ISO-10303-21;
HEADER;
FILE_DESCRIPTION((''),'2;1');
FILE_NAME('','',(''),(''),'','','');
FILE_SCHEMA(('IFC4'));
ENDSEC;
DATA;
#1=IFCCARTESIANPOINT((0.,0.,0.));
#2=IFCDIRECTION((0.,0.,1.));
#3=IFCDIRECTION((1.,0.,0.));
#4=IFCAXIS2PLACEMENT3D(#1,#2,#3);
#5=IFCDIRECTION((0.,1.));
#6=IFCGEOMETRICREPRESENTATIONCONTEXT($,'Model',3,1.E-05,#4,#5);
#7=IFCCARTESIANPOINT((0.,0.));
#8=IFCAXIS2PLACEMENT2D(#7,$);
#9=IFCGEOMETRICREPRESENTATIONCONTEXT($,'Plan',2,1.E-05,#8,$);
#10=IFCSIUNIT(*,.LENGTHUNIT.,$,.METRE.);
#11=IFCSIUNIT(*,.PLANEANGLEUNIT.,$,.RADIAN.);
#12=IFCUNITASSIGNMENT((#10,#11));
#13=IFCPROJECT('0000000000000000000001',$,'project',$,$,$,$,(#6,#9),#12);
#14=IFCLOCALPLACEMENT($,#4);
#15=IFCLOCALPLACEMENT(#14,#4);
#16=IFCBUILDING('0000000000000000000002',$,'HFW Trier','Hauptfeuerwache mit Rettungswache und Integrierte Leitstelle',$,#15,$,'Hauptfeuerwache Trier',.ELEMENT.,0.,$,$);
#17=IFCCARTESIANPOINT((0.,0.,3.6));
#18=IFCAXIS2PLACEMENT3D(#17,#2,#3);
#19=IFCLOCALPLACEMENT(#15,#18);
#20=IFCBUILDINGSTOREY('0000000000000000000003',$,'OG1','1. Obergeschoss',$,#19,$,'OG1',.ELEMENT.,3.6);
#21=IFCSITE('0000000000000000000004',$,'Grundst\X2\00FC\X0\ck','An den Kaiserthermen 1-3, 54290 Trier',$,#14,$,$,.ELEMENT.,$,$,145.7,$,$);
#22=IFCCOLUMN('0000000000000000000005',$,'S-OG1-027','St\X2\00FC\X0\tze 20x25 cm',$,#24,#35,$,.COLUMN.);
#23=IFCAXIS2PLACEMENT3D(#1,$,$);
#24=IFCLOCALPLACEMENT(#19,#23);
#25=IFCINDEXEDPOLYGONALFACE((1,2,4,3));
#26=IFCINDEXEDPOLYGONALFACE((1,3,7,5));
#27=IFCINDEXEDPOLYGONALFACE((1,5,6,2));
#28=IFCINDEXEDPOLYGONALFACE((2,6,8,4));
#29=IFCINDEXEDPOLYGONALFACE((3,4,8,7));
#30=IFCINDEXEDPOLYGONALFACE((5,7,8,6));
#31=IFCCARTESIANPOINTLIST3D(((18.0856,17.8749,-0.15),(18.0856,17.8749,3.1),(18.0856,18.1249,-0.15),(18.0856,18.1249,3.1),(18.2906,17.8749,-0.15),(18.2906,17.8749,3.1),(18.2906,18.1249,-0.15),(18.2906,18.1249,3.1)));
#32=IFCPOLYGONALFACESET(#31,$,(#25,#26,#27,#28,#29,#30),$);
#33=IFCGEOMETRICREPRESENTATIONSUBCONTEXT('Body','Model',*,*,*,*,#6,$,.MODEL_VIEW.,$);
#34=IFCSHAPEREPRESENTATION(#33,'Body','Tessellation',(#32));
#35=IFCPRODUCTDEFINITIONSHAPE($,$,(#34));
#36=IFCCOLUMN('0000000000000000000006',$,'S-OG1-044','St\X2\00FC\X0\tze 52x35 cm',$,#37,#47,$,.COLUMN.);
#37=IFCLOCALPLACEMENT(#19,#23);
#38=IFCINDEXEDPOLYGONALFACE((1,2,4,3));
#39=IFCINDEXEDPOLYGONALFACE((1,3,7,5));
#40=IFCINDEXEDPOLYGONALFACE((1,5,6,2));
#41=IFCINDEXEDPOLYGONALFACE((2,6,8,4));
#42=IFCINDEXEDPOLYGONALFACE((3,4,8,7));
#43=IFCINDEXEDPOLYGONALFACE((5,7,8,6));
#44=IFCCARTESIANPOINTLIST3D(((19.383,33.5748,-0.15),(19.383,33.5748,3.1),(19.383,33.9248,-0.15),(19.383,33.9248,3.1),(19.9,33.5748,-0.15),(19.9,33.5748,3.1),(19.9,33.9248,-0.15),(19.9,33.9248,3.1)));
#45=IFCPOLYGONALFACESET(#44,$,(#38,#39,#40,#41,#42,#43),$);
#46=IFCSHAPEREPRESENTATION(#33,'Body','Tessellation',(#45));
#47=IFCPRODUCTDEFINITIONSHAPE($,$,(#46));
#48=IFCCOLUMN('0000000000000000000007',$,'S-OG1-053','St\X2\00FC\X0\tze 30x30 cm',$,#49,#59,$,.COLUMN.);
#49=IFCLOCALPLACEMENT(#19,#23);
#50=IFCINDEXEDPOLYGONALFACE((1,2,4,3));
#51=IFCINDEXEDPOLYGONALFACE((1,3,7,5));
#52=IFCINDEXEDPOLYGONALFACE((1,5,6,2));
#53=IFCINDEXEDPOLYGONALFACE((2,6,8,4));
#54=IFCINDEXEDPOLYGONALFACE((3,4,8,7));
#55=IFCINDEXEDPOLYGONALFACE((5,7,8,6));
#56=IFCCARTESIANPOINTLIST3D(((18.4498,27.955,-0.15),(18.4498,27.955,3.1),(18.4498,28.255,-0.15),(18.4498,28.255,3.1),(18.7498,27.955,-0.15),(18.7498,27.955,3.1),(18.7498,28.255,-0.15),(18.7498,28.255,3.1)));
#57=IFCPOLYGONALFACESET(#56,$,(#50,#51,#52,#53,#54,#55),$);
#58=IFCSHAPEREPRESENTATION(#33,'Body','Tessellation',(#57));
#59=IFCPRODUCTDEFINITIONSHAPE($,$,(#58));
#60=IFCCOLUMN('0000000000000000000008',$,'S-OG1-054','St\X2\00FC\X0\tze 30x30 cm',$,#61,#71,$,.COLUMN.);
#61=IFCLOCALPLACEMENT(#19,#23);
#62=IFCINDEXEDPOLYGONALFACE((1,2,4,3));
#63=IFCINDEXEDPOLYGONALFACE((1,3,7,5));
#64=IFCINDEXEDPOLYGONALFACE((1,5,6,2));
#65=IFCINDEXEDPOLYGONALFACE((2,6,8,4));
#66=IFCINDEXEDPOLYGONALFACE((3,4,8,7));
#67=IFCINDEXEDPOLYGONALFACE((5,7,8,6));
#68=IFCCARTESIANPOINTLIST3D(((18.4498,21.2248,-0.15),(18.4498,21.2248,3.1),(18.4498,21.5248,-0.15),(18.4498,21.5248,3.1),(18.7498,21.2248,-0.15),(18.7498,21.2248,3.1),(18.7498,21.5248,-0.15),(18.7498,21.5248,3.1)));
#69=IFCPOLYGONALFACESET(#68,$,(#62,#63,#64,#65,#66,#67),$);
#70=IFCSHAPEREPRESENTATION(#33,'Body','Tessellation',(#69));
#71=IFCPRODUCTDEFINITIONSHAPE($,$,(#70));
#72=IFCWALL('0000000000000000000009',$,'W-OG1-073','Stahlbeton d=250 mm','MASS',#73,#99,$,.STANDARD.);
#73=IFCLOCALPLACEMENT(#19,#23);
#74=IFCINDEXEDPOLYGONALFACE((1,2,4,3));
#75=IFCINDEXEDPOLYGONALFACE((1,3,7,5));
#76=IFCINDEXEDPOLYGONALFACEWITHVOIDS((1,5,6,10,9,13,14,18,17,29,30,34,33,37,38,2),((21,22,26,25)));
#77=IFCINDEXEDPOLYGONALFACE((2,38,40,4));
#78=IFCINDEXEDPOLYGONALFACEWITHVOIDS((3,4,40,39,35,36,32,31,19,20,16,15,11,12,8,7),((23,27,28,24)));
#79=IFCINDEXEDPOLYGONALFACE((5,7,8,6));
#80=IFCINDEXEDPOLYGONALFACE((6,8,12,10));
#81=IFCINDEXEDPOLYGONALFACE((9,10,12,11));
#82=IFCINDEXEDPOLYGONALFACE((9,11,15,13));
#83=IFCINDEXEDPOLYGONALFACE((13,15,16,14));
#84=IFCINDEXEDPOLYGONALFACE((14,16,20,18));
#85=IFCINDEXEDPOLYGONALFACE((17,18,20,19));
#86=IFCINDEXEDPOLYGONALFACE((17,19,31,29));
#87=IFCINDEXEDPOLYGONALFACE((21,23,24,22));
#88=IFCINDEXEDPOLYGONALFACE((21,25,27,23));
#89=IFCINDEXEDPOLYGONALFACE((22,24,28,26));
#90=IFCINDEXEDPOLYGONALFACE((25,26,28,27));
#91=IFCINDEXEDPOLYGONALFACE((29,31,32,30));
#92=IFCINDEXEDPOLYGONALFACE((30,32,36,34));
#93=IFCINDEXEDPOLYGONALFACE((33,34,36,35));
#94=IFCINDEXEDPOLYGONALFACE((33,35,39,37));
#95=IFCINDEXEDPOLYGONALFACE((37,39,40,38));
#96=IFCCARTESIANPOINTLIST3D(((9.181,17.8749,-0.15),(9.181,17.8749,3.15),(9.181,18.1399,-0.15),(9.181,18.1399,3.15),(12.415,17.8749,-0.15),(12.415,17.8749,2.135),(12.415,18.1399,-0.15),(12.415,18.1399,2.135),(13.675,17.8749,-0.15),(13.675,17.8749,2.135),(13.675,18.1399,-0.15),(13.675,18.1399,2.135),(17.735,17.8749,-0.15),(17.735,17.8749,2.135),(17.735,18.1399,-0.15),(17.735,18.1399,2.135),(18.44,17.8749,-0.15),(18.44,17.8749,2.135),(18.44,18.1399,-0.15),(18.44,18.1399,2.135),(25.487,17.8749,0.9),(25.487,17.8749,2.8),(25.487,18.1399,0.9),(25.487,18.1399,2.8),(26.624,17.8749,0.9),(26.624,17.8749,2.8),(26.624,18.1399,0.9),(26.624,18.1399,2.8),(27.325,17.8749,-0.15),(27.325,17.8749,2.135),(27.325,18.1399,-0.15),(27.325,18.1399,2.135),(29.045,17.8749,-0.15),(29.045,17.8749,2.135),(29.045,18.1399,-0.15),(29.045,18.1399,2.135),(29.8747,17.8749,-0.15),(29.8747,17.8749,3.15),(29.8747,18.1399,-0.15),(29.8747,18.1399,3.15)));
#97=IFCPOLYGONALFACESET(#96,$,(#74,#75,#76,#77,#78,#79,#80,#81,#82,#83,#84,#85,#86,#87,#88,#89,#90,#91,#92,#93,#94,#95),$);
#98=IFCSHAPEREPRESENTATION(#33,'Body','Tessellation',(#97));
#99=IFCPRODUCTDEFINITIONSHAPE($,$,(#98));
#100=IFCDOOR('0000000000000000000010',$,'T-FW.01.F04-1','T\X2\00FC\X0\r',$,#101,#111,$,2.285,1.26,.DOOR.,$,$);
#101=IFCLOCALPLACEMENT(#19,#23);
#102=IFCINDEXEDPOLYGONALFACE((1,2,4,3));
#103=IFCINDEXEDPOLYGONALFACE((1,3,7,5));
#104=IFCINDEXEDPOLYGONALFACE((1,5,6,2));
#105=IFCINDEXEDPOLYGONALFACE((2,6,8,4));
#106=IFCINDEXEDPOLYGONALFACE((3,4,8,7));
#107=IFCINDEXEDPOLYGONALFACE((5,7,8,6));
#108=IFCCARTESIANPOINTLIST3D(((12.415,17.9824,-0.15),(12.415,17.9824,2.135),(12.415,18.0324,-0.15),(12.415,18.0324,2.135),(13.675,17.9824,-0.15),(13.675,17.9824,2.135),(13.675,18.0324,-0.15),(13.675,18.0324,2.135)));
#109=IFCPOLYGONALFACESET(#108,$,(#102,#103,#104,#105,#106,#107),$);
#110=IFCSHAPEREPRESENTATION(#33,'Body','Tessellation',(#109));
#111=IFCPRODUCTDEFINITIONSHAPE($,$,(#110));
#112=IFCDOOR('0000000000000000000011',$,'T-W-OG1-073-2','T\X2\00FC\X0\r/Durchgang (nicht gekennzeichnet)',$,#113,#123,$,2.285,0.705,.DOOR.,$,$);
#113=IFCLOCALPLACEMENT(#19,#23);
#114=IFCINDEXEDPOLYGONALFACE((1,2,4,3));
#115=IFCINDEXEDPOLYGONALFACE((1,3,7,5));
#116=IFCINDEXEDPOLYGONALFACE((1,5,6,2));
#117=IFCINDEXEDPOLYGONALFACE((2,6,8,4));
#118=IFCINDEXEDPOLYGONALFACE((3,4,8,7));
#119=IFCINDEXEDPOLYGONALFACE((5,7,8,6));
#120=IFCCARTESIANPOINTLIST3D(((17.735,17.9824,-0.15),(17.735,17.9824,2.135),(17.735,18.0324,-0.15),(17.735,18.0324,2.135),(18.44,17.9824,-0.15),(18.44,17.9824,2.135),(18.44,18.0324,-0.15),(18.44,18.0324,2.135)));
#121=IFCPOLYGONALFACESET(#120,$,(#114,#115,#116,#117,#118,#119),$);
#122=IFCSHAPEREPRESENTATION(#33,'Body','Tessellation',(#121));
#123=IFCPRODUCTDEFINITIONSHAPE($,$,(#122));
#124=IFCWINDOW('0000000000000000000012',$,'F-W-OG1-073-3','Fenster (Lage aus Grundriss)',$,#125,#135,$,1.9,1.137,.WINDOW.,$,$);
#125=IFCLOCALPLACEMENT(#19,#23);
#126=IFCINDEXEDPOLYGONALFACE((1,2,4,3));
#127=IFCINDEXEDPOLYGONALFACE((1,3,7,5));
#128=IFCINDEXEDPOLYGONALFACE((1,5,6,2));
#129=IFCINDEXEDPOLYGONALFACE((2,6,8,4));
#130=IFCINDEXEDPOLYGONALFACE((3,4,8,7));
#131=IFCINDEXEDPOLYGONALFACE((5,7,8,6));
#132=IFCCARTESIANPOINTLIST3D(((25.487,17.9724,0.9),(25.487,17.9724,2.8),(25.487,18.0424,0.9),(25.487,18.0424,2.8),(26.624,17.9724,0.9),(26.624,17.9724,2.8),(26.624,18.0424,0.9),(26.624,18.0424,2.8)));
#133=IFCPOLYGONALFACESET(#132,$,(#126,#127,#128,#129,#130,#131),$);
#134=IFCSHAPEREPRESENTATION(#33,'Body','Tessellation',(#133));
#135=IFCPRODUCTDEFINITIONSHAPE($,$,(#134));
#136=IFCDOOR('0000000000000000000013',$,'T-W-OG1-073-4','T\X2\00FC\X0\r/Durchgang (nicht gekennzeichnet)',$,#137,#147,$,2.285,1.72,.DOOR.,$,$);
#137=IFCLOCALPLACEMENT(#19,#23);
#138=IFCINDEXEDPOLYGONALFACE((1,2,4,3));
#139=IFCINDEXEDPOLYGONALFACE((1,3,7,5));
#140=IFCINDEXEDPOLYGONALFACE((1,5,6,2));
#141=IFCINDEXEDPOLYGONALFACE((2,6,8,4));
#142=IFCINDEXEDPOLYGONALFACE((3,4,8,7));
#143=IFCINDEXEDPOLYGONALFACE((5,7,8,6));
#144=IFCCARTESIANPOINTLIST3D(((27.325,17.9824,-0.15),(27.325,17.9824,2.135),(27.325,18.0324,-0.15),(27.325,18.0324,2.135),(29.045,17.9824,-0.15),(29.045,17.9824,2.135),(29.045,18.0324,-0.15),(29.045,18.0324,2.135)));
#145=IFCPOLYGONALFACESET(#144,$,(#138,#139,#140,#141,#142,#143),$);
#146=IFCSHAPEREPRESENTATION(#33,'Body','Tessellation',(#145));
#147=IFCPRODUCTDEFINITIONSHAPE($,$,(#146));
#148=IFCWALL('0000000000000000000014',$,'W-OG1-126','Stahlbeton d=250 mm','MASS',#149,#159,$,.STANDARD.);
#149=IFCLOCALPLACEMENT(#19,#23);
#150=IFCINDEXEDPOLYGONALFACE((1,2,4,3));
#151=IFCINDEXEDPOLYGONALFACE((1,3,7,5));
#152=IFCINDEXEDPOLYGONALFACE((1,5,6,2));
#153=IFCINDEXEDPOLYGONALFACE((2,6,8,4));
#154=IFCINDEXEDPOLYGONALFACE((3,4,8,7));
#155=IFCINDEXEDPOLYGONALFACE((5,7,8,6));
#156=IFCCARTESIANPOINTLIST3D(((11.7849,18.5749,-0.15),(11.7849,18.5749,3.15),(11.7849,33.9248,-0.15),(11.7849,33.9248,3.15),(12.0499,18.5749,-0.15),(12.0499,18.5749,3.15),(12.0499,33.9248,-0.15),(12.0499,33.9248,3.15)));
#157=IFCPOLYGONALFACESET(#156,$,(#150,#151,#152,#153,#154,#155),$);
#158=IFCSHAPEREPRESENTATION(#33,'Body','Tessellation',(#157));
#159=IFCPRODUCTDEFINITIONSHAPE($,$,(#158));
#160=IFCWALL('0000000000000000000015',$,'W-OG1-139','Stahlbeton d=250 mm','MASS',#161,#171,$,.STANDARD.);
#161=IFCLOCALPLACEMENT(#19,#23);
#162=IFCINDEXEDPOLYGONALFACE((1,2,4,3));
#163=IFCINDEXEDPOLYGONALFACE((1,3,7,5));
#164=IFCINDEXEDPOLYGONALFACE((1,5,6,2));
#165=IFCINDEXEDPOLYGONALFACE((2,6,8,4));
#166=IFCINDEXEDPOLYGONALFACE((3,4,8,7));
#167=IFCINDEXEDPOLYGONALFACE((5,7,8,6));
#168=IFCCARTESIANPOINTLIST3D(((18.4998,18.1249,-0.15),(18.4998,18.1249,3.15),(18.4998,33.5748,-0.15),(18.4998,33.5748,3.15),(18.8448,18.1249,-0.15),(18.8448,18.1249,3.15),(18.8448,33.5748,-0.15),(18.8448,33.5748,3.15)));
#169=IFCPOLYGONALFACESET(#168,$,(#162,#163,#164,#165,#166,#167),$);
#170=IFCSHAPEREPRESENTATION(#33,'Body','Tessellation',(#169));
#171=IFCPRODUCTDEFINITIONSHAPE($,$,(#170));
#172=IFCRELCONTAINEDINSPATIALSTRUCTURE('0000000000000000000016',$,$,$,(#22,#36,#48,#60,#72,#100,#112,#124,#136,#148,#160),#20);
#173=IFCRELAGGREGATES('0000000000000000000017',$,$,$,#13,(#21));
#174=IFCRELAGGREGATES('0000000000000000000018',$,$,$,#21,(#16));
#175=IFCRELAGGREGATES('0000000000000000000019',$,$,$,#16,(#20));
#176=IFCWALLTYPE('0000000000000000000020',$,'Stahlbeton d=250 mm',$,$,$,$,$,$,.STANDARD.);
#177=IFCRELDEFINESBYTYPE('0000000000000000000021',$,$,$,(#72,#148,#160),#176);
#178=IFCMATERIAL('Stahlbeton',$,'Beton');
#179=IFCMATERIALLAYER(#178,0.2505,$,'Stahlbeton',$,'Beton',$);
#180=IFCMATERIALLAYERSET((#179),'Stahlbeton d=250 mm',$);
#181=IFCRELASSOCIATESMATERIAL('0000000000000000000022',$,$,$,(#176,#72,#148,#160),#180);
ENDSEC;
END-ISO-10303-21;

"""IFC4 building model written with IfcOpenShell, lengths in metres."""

from ifc_helpers import new_model, si_unit, direction, frame, frame_2d, origin_with_axes, origin_2d, place, context, subcontext, project, spatial, rectangle, extrude, material, layer, layer_set, layer_usage, type_object, element, fill, save


model = new_model("IFC4")

# Units and contexts
model_context = context("Model", 3, precision=1e-05, world=origin_with_axes(), true_north=direction((0.0, 1.0)))
plan_context = context("Plan", 2, precision=1e-05, world=origin_2d())
body_context = subcontext(model_context, "Body", "Model", "MODEL_VIEW")
ifc_project = project(units=[si_unit("LENGTHUNIT", "METRE"), si_unit("PLANEANGLEUNIT", "RADIAN")], contexts=[model_context, plan_context])

# Site, building, storey
site_placement = place(None, origin_with_axes())
site = spatial("IfcSite", under=ifc_project, at=site_placement, Name="Grundstück", Description="An den Kaiserthermen 1-3, 54290 Trier", CompositionType="ELEMENT", RefElevation=145.7)
building_placement = place(site_placement, origin_with_axes())
building = spatial("IfcBuilding", under=site, at=building_placement, Name="HFW Trier", Description="Hauptfeuerwache mit Rettungswache und Integrierte Leitstelle", LongName="Hauptfeuerwache Trier", CompositionType="ELEMENT", ElevationOfRefHeight=0.0)
storey_placement = place(building_placement, frame((0.0, 0.0, 3.6), z_axis=(0.0, 0.0, 1.0), x_axis=(1.0, 0.0, 0.0)))
storey = spatial("IfcBuildingStorey", under=building, at=storey_placement, Name="OG1", Description="1. Obergeschoss", LongName="OG1", CompositionType="ELEMENT", Elevation=3.6)

# Columns
column_1_placement = place(storey_placement, frame((18.0856, 17.9999, -0.15), z_axis=(0.0, 0.0, 1.0), x_axis=(1.0, 0.0, 0.0)))
element("IfcColumn", 1, at=column_1_placement, inside=storey, Name="S-OG1-027", Description="Stütze 20x25 cm", PredefinedType="COLUMN", context=body_context, shape_type="SweptSolid", body=[
    extrude(rectangle(XDim=0.205, YDim=0.25, at=frame_2d((0.1025, 0.0))), origin_with_axes(), (0.0, 0.0, 1.0), 3.25),
])
column_2_placement = place(storey_placement, frame((19.383, 33.7498, -0.15), z_axis=(0.0, 0.0, 1.0), x_axis=(1.0, 0.0, 0.0)))
element("IfcColumn", 2, at=column_2_placement, inside=storey, Name="S-OG1-044", Description="Stütze 52x35 cm", PredefinedType="COLUMN", context=body_context, shape_type="SweptSolid", body=[
    extrude(rectangle(XDim=0.517, YDim=0.35, at=frame_2d((0.2585, 0.0))), origin_with_axes(), (0.0, 0.0, 1.0), 3.25),
])
for number, where, z_axis, x_axis, name in (
    (3, (18.4498, 28.105, -0.15), (0.0, 0.0, 1.0), (1.0, 0.0, 0.0), "S-OG1-053"),
    (4, (18.4498, 21.3748, -0.15), (0.0, 0.0, 1.0), (1.0, 0.0, 0.0), "S-OG1-054"),
):
    element("IfcColumn", number, at=place(storey_placement, frame(where, z_axis=z_axis, x_axis=x_axis)), inside=storey, Name=name, Description="Stütze 30x30 cm", PredefinedType="COLUMN", context=body_context, shape_type="SweptSolid", body=[
        extrude(rectangle(XDim=0.3, YDim=0.3, at=frame_2d((0.15, 0.0))), origin_with_axes(), (0.0, 0.0, 1.0), 3.25),
    ])

# Wall, openings, doors, window
ifc_material_1 = material(Name="Stahlbeton", Category="Beton")
ifc_layer_1 = layer(ifc_material_1, 0.2505, Name="Stahlbeton", Category="Beton")
ifc_layer_set_1 = layer_set([ifc_layer_1], Name="Stahlbeton d=250 mm")
ifc_layer_usage_1 = layer_usage(ifc_layer_set_1, "AXIS2", "POSITIVE", -0.1325)
wall_type_1 = type_object("IfcWallType", Name="Stahlbeton d=250 mm", PredefinedType="STANDARD", material=ifc_layer_set_1)
wall_1_placement = place(storey_placement, frame((9.181, 18.0074, -0.15), z_axis=(0.0, 0.0, 1.0), x_axis=(1.0, 0.0, 0.0)))
wall_1 = element("IfcWall", 5, at=wall_1_placement, inside=storey, type_object=wall_type_1, material=ifc_layer_usage_1, Name="W-OG1-073", Description="Stahlbeton d=250 mm", ObjectType="MASS", PredefinedType="STANDARD", context=body_context, shape_type="SweptSolid", body=[
    extrude(rectangle(XDim=20.6937, YDim=0.265, at=frame_2d((10.3468, 0.0))), origin_with_axes(), (0.0, 0.0, 1.0), 3.3),
])
opening_1_placement = place(wall_1_placement, frame((3.234, 0.0, 0.0), z_axis=(0.0, 0.0, 1.0), x_axis=(1.0, 0.0, 0.0)))
opening_1 = element("IfcOpeningElement", 6, at=opening_1_placement, cuts=wall_1, PredefinedType="OPENING", context=body_context, shape_type="SweptSolid", body=[
    extrude(rectangle(XDim=1.26, YDim=0.365, at=frame_2d((0.63, 0.0))), origin_with_axes(), (0.0, 0.0, 1.0), 2.285),
])
opening_2_placement = place(wall_1_placement, frame((8.554, 0.0, 0.0), z_axis=(0.0, 0.0, 1.0), x_axis=(1.0, 0.0, 0.0)))
opening_2 = element("IfcOpeningElement", 7, at=opening_2_placement, cuts=wall_1, PredefinedType="OPENING", context=body_context, shape_type="SweptSolid", body=[
    extrude(rectangle(XDim=0.705, YDim=0.365, at=frame_2d((0.3525, 0.0))), origin_with_axes(), (0.0, 0.0, 1.0), 2.285),
])
opening_3_placement = place(wall_1_placement, frame((16.306, 0.0, 0.0), z_axis=(0.0, 0.0, 1.0), x_axis=(1.0, 0.0, 0.0)))
opening_3 = element("IfcOpeningElement", 8, at=opening_3_placement, cuts=wall_1, PredefinedType="OPENING", context=body_context, shape_type="SweptSolid", body=[
    extrude(rectangle(XDim=1.137, YDim=0.365, at=frame_2d((0.5685, 0.0))), frame((0.0, 0.0, 1.05), z_axis=(0.0, 0.0, 1.0), x_axis=(1.0, 0.0, 0.0)), (0.0, 0.0, 1.0), 1.9),
])
opening_4_placement = place(wall_1_placement, frame((18.144, 0.0, 0.0), z_axis=(0.0, 0.0, 1.0), x_axis=(1.0, 0.0, 0.0)))
opening_4 = element("IfcOpeningElement", 9, at=opening_4_placement, cuts=wall_1, PredefinedType="OPENING", context=body_context, shape_type="SweptSolid", body=[
    extrude(rectangle(XDim=1.72, YDim=0.365, at=frame_2d((0.86, 0.0))), origin_with_axes(), (0.0, 0.0, 1.0), 2.285),
])
door_1_placement = place(wall_1_placement, frame((3.234, 0.0, 0.0), z_axis=(0.0, 0.0, 1.0), x_axis=(1.0, 0.0, 0.0)))
door_1 = element("IfcDoor", 10, at=door_1_placement, inside=storey, Name="T-FW.01.F04-1", Description="Tür", OverallHeight=2.285, OverallWidth=1.26, PredefinedType="DOOR", context=body_context, shape_type="SweptSolid", body=[
    extrude(rectangle(XDim=1.26, YDim=0.05, at=frame_2d((0.63, 0.0))), origin_with_axes(), (0.0, 0.0, 1.0), 2.285),
])
fill(opening_1, door_1)
door_2_placement = place(wall_1_placement, frame((8.554, 0.0, 0.0), z_axis=(0.0, 0.0, 1.0), x_axis=(1.0, 0.0, 0.0)))
door_2 = element("IfcDoor", 11, at=door_2_placement, inside=storey, Name="T-W-OG1-073-2", Description="Tür/Durchgang (nicht gekennzeichnet)", OverallHeight=2.285, OverallWidth=0.705, PredefinedType="DOOR", context=body_context, shape_type="SweptSolid", body=[
    extrude(rectangle(XDim=0.705, YDim=0.05, at=frame_2d((0.3525, 0.0))), origin_with_axes(), (0.0, 0.0, 1.0), 2.285),
])
fill(opening_2, door_2)
window_placement = place(wall_1_placement, frame((16.306, 0.0, 0.0), z_axis=(0.0, 0.0, 1.0), x_axis=(1.0, 0.0, 0.0)))
window = element("IfcWindow", 12, at=window_placement, inside=storey, Name="F-W-OG1-073-3", Description="Fenster (Lage aus Grundriss)", OverallHeight=1.9, OverallWidth=1.137, PredefinedType="WINDOW", context=body_context, shape_type="SweptSolid", body=[
    extrude(rectangle(XDim=1.137, YDim=0.07, at=frame_2d((0.5685, 0.0))), frame((0.0, 0.0, 1.05), z_axis=(0.0, 0.0, 1.0), x_axis=(1.0, 0.0, 0.0)), (0.0, 0.0, 1.0), 1.9),
])
fill(opening_3, window)
door_3_placement = place(wall_1_placement, frame((18.144, 0.0, 0.0), z_axis=(0.0, 0.0, 1.0), x_axis=(1.0, 0.0, 0.0)))
door_3 = element("IfcDoor", 13, at=door_3_placement, inside=storey, Name="T-W-OG1-073-4", Description="Tür/Durchgang (nicht gekennzeichnet)", OverallHeight=2.285, OverallWidth=1.72, PredefinedType="DOOR", context=body_context, shape_type="SweptSolid", body=[
    extrude(rectangle(XDim=1.72, YDim=0.05, at=frame_2d((0.86, 0.0))), origin_with_axes(), (0.0, 0.0, 1.0), 2.285),
])
fill(opening_4, door_3)

# Walls
ifc_layer_usage_2 = layer_usage(ifc_layer_set_1, "AXIS2", "POSITIVE", -0.1325)
wall_2_placement = place(storey_placement, frame((11.9174, 33.9248, -0.15), z_axis=(0.0, 0.0, 1.0), x_axis=(0.0, -1.0, 0.0)))
element("IfcWall", 14, at=wall_2_placement, inside=storey, type_object=wall_type_1, material=ifc_layer_usage_2, Name="W-OG1-126", Description="Stahlbeton d=250 mm", ObjectType="MASS", PredefinedType="STANDARD", context=body_context, shape_type="SweptSolid", body=[
    extrude(rectangle(XDim=15.3499, YDim=0.265, at=frame_2d((7.6749, 0.0))), origin_with_axes(), (0.0, 0.0, 1.0), 3.3),
])
ifc_layer_usage_3 = layer_usage(ifc_layer_set_1, "AXIS2", "POSITIVE", -0.1725)
wall_3_placement = place(storey_placement, frame((18.6723, 33.5748, -0.15), z_axis=(0.0, 0.0, 1.0), x_axis=(0.0, -1.0, 0.0)))
element("IfcWall", 15, at=wall_3_placement, inside=storey, type_object=wall_type_1, material=ifc_layer_usage_3, Name="W-OG1-139", Description="Stahlbeton d=250 mm", ObjectType="MASS", PredefinedType="STANDARD", context=body_context, shape_type="SweptSolid", body=[
    extrude(rectangle(XDim=15.4499, YDim=0.345, at=frame_2d((7.725, 0.0))), origin_with_axes(), (0.0, 0.0, 1.0), 3.3),
])

save(model, "model.ifc")
